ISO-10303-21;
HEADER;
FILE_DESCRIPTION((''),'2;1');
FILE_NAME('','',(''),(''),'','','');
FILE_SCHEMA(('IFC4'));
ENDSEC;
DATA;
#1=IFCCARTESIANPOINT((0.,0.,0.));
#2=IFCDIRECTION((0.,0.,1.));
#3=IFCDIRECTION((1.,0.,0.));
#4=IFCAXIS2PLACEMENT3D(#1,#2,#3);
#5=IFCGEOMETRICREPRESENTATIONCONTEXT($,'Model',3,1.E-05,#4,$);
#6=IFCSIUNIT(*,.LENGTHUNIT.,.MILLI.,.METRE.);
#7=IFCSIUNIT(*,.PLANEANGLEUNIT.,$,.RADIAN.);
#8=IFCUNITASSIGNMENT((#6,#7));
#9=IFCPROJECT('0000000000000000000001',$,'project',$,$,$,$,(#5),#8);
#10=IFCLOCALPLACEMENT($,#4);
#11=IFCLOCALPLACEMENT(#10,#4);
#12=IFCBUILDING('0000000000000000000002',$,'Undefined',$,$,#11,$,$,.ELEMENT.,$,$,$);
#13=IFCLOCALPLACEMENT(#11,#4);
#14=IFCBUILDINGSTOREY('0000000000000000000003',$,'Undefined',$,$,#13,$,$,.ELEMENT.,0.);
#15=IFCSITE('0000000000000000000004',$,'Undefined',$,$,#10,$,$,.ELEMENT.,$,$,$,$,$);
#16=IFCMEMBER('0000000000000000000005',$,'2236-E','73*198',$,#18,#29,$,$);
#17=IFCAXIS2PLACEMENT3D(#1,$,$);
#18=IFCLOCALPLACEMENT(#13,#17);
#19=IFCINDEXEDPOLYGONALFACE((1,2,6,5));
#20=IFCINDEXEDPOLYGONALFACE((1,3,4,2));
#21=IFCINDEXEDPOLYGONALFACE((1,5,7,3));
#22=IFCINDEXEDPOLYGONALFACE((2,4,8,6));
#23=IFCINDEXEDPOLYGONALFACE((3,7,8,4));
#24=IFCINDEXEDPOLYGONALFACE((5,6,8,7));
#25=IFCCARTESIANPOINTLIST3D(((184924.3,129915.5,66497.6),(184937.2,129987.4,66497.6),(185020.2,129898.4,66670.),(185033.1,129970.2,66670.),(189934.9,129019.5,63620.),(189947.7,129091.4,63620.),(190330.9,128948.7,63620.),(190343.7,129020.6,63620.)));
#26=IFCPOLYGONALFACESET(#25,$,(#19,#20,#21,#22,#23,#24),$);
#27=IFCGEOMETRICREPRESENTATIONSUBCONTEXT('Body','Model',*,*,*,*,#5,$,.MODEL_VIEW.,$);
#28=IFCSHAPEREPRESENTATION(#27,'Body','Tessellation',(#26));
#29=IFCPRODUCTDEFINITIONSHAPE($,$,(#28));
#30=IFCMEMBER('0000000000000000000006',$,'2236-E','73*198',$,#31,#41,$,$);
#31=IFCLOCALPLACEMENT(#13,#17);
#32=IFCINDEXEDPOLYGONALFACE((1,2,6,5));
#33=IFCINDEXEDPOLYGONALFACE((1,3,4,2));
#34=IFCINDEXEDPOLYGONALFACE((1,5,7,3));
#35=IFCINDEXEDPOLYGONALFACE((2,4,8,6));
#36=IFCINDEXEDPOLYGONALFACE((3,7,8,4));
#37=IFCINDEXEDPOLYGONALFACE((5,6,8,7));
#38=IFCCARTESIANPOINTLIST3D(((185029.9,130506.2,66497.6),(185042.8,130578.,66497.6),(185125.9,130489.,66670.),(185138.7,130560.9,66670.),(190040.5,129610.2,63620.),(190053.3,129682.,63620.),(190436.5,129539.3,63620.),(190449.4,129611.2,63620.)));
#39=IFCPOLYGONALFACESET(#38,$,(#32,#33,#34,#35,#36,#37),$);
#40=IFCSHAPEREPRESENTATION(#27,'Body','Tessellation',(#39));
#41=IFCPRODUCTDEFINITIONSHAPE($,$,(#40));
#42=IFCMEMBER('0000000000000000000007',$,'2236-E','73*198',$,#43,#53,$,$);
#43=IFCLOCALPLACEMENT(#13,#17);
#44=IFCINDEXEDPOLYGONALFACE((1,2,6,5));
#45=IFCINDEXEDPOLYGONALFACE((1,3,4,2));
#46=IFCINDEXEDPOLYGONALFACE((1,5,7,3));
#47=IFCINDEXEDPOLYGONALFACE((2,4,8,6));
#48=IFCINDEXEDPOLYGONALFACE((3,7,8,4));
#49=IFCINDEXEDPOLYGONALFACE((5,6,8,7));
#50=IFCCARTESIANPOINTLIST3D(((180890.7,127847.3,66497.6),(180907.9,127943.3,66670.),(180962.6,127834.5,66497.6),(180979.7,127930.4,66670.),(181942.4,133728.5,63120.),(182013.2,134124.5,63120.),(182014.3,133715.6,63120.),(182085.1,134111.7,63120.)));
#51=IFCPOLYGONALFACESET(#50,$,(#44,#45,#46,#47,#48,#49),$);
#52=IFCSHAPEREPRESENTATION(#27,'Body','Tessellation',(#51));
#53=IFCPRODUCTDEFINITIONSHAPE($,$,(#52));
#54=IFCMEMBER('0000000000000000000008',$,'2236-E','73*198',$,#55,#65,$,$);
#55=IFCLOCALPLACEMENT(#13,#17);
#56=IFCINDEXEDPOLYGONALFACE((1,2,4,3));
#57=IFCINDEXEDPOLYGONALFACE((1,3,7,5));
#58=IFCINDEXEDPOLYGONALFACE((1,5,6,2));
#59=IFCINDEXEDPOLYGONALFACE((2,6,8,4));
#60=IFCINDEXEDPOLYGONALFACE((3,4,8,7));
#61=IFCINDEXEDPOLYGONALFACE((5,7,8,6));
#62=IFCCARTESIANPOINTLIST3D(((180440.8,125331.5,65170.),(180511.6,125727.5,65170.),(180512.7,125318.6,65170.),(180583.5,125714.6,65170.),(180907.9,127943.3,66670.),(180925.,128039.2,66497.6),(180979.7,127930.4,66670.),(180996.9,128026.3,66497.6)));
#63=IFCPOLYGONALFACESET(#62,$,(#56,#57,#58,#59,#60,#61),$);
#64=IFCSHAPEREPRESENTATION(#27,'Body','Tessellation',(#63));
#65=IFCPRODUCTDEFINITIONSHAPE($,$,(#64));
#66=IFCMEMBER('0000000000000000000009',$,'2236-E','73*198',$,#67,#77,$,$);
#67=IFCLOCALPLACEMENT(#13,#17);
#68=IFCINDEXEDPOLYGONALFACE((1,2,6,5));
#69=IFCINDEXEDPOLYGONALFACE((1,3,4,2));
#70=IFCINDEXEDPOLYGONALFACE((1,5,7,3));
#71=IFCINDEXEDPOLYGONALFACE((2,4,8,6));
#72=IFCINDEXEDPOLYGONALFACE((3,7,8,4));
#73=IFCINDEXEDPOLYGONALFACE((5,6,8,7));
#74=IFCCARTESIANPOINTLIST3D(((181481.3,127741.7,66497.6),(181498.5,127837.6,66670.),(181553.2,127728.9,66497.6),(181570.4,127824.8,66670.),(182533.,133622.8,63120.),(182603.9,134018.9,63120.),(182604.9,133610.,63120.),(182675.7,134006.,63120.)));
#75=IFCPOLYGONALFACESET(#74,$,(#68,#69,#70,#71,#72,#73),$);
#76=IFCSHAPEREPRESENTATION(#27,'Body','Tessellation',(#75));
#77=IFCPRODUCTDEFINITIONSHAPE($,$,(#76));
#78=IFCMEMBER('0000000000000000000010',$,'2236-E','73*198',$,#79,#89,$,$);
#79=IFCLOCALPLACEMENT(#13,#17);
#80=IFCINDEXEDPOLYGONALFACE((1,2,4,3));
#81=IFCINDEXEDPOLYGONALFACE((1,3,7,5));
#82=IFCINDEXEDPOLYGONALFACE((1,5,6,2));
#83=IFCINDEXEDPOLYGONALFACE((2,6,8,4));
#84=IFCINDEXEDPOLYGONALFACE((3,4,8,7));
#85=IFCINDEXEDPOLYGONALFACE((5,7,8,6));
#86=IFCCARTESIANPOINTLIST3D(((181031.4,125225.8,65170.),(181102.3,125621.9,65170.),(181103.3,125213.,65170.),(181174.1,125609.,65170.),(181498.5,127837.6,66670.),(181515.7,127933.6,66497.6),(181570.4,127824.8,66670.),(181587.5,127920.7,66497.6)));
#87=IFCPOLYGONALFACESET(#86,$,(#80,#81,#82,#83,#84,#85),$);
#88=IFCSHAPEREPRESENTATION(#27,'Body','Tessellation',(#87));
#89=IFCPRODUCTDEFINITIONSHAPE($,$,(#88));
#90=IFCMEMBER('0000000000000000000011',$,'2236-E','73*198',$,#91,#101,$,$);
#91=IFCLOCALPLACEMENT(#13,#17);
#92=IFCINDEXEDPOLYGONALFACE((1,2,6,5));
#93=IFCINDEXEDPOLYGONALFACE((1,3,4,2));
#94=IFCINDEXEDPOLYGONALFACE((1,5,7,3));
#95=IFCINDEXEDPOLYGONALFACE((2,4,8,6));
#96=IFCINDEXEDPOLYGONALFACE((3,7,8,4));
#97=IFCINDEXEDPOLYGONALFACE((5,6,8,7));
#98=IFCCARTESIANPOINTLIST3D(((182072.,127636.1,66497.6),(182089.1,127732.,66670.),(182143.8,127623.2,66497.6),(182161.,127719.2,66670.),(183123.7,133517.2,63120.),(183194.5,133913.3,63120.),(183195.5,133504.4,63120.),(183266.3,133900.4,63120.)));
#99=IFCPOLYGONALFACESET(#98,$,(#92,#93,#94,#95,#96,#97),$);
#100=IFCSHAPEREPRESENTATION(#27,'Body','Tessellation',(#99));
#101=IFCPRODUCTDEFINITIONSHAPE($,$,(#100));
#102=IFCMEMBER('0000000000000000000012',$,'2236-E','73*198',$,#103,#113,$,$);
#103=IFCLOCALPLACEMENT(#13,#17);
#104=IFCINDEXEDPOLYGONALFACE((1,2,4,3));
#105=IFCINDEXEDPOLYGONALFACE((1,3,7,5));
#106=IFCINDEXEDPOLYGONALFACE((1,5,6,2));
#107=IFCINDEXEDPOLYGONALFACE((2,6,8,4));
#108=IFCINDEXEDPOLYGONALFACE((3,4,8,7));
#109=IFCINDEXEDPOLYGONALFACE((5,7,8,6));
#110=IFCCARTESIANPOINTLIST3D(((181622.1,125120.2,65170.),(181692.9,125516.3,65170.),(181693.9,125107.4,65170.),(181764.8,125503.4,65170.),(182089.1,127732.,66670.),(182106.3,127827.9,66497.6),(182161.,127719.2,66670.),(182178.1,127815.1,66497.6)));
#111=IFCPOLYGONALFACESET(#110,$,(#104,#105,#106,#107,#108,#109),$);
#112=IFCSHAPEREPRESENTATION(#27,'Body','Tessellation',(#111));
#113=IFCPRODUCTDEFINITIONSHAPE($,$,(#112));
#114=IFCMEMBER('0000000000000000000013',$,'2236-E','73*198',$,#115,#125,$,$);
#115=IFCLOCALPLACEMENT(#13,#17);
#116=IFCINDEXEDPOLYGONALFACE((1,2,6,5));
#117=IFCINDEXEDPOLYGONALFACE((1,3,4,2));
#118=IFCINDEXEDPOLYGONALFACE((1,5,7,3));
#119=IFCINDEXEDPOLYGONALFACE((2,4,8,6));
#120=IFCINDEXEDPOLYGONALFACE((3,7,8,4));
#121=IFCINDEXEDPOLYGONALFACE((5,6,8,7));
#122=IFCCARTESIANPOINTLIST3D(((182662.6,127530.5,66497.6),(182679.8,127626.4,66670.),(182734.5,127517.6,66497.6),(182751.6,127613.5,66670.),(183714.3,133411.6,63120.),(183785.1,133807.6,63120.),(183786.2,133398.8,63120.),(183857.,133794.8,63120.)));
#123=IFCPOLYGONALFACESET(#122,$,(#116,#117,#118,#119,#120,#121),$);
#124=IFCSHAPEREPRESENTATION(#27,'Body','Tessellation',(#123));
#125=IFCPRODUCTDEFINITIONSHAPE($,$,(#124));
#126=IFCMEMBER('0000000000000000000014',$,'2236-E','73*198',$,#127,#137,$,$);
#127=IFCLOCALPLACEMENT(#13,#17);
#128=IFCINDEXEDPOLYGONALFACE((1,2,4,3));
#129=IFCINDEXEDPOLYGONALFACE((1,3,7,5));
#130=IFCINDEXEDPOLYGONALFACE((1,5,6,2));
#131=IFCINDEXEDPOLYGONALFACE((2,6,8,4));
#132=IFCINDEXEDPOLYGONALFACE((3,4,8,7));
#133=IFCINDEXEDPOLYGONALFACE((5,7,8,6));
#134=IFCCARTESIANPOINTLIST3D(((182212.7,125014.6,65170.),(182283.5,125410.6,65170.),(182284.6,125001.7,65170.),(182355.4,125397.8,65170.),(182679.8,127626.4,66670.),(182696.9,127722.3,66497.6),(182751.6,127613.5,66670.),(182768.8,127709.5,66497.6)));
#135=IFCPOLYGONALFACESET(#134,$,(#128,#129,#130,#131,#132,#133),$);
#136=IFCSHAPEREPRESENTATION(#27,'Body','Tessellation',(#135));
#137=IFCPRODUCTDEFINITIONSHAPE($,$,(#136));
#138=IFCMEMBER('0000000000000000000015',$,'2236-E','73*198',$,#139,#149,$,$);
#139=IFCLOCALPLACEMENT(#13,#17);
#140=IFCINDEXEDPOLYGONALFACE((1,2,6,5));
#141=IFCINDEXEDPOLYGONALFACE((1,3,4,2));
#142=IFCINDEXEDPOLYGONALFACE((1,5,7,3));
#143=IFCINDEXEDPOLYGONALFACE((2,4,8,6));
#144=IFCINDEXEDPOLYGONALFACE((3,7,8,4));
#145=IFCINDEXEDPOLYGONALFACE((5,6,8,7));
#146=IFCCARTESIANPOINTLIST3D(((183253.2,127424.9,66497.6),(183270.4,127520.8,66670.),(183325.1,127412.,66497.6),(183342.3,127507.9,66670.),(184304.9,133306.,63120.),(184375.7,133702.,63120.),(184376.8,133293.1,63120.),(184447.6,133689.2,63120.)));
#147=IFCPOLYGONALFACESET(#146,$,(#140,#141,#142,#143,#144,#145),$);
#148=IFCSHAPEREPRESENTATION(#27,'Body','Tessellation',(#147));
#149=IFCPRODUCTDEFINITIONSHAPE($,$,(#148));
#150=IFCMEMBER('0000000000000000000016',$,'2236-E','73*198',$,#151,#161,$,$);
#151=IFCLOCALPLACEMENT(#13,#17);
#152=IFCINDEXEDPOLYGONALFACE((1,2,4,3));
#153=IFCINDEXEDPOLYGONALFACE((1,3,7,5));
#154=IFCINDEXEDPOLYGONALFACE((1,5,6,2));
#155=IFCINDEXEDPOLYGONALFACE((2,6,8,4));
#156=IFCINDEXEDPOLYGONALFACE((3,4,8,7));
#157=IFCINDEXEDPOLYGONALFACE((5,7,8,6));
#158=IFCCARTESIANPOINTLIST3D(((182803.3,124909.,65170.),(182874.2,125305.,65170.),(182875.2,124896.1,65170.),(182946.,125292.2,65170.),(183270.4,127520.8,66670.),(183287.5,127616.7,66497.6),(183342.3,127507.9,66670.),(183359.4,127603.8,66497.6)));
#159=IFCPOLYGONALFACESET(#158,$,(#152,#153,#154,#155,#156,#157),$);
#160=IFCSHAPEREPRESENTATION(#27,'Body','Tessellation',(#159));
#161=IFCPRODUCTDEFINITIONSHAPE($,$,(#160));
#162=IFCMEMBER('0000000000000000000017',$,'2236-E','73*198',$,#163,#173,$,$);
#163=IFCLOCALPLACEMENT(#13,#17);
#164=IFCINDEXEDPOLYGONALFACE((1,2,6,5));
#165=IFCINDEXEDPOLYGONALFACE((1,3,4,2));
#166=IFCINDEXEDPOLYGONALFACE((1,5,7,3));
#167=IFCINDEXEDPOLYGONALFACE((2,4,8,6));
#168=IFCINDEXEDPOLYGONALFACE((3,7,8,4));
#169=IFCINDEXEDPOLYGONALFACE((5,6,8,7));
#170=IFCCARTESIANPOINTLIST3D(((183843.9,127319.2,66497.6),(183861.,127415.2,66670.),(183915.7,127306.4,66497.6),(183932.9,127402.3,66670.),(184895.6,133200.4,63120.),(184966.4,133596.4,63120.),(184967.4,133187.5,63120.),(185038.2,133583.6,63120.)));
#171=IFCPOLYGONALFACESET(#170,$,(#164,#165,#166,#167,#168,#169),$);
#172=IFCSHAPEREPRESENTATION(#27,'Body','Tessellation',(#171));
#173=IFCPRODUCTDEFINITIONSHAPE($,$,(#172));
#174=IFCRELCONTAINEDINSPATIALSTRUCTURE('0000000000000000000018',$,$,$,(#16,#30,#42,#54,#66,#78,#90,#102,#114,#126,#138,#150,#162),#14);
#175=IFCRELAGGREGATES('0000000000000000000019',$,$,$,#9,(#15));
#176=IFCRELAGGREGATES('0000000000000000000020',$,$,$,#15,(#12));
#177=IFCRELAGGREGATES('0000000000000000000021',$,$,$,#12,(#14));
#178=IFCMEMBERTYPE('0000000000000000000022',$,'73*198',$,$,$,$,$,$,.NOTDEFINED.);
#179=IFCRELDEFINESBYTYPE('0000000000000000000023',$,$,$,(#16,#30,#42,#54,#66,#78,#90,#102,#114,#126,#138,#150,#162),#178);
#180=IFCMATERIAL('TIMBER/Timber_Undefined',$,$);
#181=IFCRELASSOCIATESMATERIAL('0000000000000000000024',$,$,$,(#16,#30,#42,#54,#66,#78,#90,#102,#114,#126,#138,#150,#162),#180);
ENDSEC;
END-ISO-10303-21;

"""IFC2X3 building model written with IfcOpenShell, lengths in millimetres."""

from ifc_helpers import new_model, si_unit, frame, origin_with_axes, origin_2d_with_axis, place, context, subcontext, project, spatial, rectangle, extrude, clip, halfspace, material, type_object, element, save


model = new_model("IFC2X3")

# Units and contexts
model_context = context("Model", 3, precision=1e-05, world=origin_with_axes())
body_context = subcontext(model_context, "Body", "Model", "MODEL_VIEW")
ifc_project = project(units=[si_unit("LENGTHUNIT", "METRE", prefix="MILLI"), si_unit("PLANEANGLEUNIT", "RADIAN")], contexts=[model_context])

# Site, building, storey
site_placement = place(None, origin_with_axes())
site = spatial("IfcSite", under=ifc_project, at=site_placement, Name="Undefined", CompositionType="ELEMENT")
building_placement = place(site_placement, origin_with_axes())
building = spatial("IfcBuilding", under=site, at=building_placement, Name="Undefined", CompositionType="ELEMENT")
storey_placement = place(building_placement, origin_with_axes())
storey = spatial("IfcBuildingStorey", under=building, at=storey_placement, Name="Undefined", CompositionType="ELEMENT", Elevation=0.0)

# Shared definitions
ifc_material = material(Name="TIMBER/Timber_Undefined")

# Members
member_type = type_object("IfcMemberType", Name="73*198", PredefinedType="NOTDEFINED")
for number, where, z_axis, x_axis, name in (
    (1, (184978.7, 129942.9, 66583.8), (-0.176032, -0.984385, 0.0), (0.85692, -0.153238, -0.492144), "2236-E"),
    (2, (185084.3, 130533.5, 66583.8), (-0.176032, -0.984385, 0.0), (0.85692, -0.153238, -0.492144), "2236-E"),
):
    element("IfcMember", number, at=place(storey_placement, frame(where, z_axis=z_axis, x_axis=x_axis)), inside=storey, type_object=member_type, material=ifc_material, Name=name, Description="73*198", context=body_context, shape_type="Clipping", body=[
        clip(extrude(rectangle(XDim=198.0, YDim=73.0, at=origin_2d_with_axis()), frame((9448.4, 0.0, 0.0), z_axis=(-1.0, 0.0, 0.0), x_axis=(0.0, -1.0, 0.0)), (0.0, 0.0, 1.0), 9448.5), halfspace(frame((6183.8, 91.3, 36.5), z_axis=(0.492144, -0.870514, 0.0), x_axis=(0.0, 0.0, -1.0)), False)),
    ])
member_1_placement = place(storey_placement, frame((180935.2, 127888.9, 66583.8), z_axis=(0.984385, -0.176032, 0.0), x_axis=(0.153238, 0.85692, -0.492144)))
element("IfcMember", 3, at=member_1_placement, inside=storey, type_object=member_type, material=ifc_material, Name="2236-E", Description="73*198", context=body_context, shape_type="Clipping", body=[
    clip(extrude(rectangle(XDim=198.0, YDim=73.0, at=origin_2d_with_axis()), frame((9448.4, 0.0, 0.0), z_axis=(-1.0, 0.0, 0.0), x_axis=(0.0, -1.0, 0.0)), (0.0, 0.0, 1.0), 9448.5), halfspace(frame((7213.3, 99.0, 36.5), z_axis=(0.492144, -0.870514, 0.0), x_axis=(0.0, 0.0, -1.0)), False)),
])
member_2_placement = place(storey_placement, frame((180952.4, 127984.8, 66583.8), z_axis=(-0.984385, 0.176032, 0.0), x_axis=(-0.153238, -0.85692, -0.492144)))
element("IfcMember", 4, at=member_2_placement, inside=storey, type_object=member_type, material=ifc_material, Name="2236-E", Description="73*198", context=body_context, shape_type="Clipping", body=[
    clip(extrude(rectangle(XDim=198.0, YDim=73.0, at=origin_2d_with_axis()), frame((9448.4, 0.0, 0.0), z_axis=(-1.0, 0.0, 0.0), x_axis=(0.0, -1.0, 0.0)), (0.0, 0.0, 1.0), 9448.5), halfspace(frame((3047.9, 99.0, 36.5), z_axis=(0.492144, -0.870514, 0.0), x_axis=(0.0, 0.0, -1.0)), False)),
])
member_3_placement = place(storey_placement, frame((181525.9, 127783.2, 66583.8), z_axis=(0.984385, -0.176032, 0.0), x_axis=(0.153238, 0.85692, -0.492144)))
element("IfcMember", 5, at=member_3_placement, inside=storey, type_object=member_type, material=ifc_material, Name="2236-E", Description="73*198", context=body_context, shape_type="Clipping", body=[
    clip(extrude(rectangle(XDim=198.0, YDim=73.0, at=origin_2d_with_axis()), frame((9448.4, 0.0, 0.0), z_axis=(-1.0, 0.0, 0.0), x_axis=(0.0, -1.0, 0.0)), (0.0, 0.0, 1.0), 9448.5), halfspace(frame((7213.3, 99.0, 36.5), z_axis=(0.492144, -0.870514, 0.0), x_axis=(0.0, 0.0, -1.0)), False)),
])
member_4_placement = place(storey_placement, frame((181543.0, 127879.2, 66583.8), z_axis=(-0.984385, 0.176032, 0.0), x_axis=(-0.153238, -0.85692, -0.492144)))
element("IfcMember", 6, at=member_4_placement, inside=storey, type_object=member_type, material=ifc_material, Name="2236-E", Description="73*198", context=body_context, shape_type="Clipping", body=[
    clip(extrude(rectangle(XDim=198.0, YDim=73.0, at=origin_2d_with_axis()), frame((9448.4, 0.0, 0.0), z_axis=(-1.0, 0.0, 0.0), x_axis=(0.0, -1.0, 0.0)), (0.0, 0.0, 1.0), 9448.5), halfspace(frame((3047.9, 99.0, 36.5), z_axis=(0.492144, -0.870514, 0.0), x_axis=(0.0, 0.0, -1.0)), False)),
])
member_5_placement = place(storey_placement, frame((182116.5, 127677.6, 66583.8), z_axis=(0.984385, -0.176032, 0.0), x_axis=(0.153238, 0.85692, -0.492144)))
element("IfcMember", 7, at=member_5_placement, inside=storey, type_object=member_type, material=ifc_material, Name="2236-E", Description="73*198", context=body_context, shape_type="Clipping", body=[
    clip(extrude(rectangle(XDim=198.0, YDim=73.0, at=origin_2d_with_axis()), frame((9448.4, 0.0, 0.0), z_axis=(-1.0, 0.0, 0.0), x_axis=(0.0, -1.0, 0.0)), (0.0, 0.0, 1.0), 9448.5), halfspace(frame((7213.3, 99.0, 36.5), z_axis=(0.492144, -0.870514, 0.0), x_axis=(0.0, 0.0, -1.0)), False)),
])
member_6_placement = place(storey_placement, frame((182133.6, 127773.5, 66583.8), z_axis=(-0.984385, 0.176032, 0.0), x_axis=(-0.153238, -0.85692, -0.492144)))
element("IfcMember", 8, at=member_6_placement, inside=storey, type_object=member_type, material=ifc_material, Name="2236-E", Description="73*198", context=body_context, shape_type="Clipping", body=[
    clip(extrude(rectangle(XDim=198.0, YDim=73.0, at=origin_2d_with_axis()), frame((9448.4, 0.0, 0.0), z_axis=(-1.0, 0.0, 0.0), x_axis=(0.0, -1.0, 0.0)), (0.0, 0.0, 1.0), 9448.5), halfspace(frame((3047.9, 99.0, 36.5), z_axis=(0.492144, -0.870514, 0.0), x_axis=(0.0, 0.0, -1.0)), False)),
])
member_7_placement = place(storey_placement, frame((182707.1, 127572.0, 66583.8), z_axis=(0.984385, -0.176032, 0.0), x_axis=(0.153238, 0.85692, -0.492144)))
element("IfcMember", 9, at=member_7_placement, inside=storey, type_object=member_type, material=ifc_material, Name="2236-E", Description="73*198", context=body_context, shape_type="Clipping", body=[
    clip(extrude(rectangle(XDim=198.0, YDim=73.0, at=origin_2d_with_axis()), frame((9448.4, 0.0, 0.0), z_axis=(-1.0, 0.0, 0.0), x_axis=(0.0, -1.0, 0.0)), (0.0, 0.0, 1.0), 9448.5), halfspace(frame((7213.3, 99.0, 36.5), z_axis=(0.492144, -0.870514, 0.0), x_axis=(0.0, 0.0, -1.0)), False)),
])
member_8_placement = place(storey_placement, frame((182724.3, 127667.9, 66583.8), z_axis=(-0.984385, 0.176032, 0.0), x_axis=(-0.153238, -0.85692, -0.492144)))
element("IfcMember", 10, at=member_8_placement, inside=storey, type_object=member_type, material=ifc_material, Name="2236-E", Description="73*198", context=body_context, shape_type="Clipping", body=[
    clip(extrude(rectangle(XDim=198.0, YDim=73.0, at=origin_2d_with_axis()), frame((9448.4, 0.0, 0.0), z_axis=(-1.0, 0.0, 0.0), x_axis=(0.0, -1.0, 0.0)), (0.0, 0.0, 1.0), 9448.5), halfspace(frame((3047.9, 99.0, 36.5), z_axis=(0.492144, -0.870514, 0.0), x_axis=(0.0, 0.0, -1.0)), False)),
])
member_9_placement = place(storey_placement, frame((183297.7, 127466.4, 66583.8), z_axis=(0.984385, -0.176032, 0.0), x_axis=(0.153238, 0.85692, -0.492144)))
element("IfcMember", 11, at=member_9_placement, inside=storey, type_object=member_type, material=ifc_material, Name="2236-E", Description="73*198", context=body_context, shape_type="Clipping", body=[
    clip(extrude(rectangle(XDim=198.0, YDim=73.0, at=origin_2d_with_axis()), frame((9448.4, 0.0, 0.0), z_axis=(-1.0, 0.0, 0.0), x_axis=(0.0, -1.0, 0.0)), (0.0, 0.0, 1.0), 9448.5), halfspace(frame((7213.3, 99.0, 36.5), z_axis=(0.492144, -0.870514, 0.0), x_axis=(0.0, 0.0, -1.0)), False)),
])
member_10_placement = place(storey_placement, frame((183314.9, 127562.3, 66583.8), z_axis=(-0.984385, 0.176032, 0.0), x_axis=(-0.153238, -0.85692, -0.492144)))
element("IfcMember", 12, at=member_10_placement, inside=storey, type_object=member_type, material=ifc_material, Name="2236-E", Description="73*198", context=body_context, shape_type="Clipping", body=[
    clip(extrude(rectangle(XDim=198.0, YDim=73.0, at=origin_2d_with_axis()), frame((9448.4, 0.0, 0.0), z_axis=(-1.0, 0.0, 0.0), x_axis=(0.0, -1.0, 0.0)), (0.0, 0.0, 1.0), 9448.5), halfspace(frame((3047.9, 99.0, 36.5), z_axis=(0.492144, -0.870514, 0.0), x_axis=(0.0, 0.0, -1.0)), False)),
])
member_11_placement = place(storey_placement, frame((183888.4, 127360.8, 66583.8), z_axis=(0.984385, -0.176032, 0.0), x_axis=(0.153238, 0.85692, -0.492144)))
element("IfcMember", 13, at=member_11_placement, inside=storey, type_object=member_type, material=ifc_material, Name="2236-E", Description="73*198", context=body_context, shape_type="Clipping", body=[
    clip(extrude(rectangle(XDim=198.0, YDim=73.0, at=origin_2d_with_axis()), frame((9448.4, 0.0, 0.0), z_axis=(-1.0, 0.0, 0.0), x_axis=(0.0, -1.0, 0.0)), (0.0, 0.0, 1.0), 9448.5), halfspace(frame((7213.3, 99.0, 36.5), z_axis=(0.492144, -0.870514, 0.0), x_axis=(0.0, 0.0, -1.0)), False)),
])

save(model, "model.ifc")
